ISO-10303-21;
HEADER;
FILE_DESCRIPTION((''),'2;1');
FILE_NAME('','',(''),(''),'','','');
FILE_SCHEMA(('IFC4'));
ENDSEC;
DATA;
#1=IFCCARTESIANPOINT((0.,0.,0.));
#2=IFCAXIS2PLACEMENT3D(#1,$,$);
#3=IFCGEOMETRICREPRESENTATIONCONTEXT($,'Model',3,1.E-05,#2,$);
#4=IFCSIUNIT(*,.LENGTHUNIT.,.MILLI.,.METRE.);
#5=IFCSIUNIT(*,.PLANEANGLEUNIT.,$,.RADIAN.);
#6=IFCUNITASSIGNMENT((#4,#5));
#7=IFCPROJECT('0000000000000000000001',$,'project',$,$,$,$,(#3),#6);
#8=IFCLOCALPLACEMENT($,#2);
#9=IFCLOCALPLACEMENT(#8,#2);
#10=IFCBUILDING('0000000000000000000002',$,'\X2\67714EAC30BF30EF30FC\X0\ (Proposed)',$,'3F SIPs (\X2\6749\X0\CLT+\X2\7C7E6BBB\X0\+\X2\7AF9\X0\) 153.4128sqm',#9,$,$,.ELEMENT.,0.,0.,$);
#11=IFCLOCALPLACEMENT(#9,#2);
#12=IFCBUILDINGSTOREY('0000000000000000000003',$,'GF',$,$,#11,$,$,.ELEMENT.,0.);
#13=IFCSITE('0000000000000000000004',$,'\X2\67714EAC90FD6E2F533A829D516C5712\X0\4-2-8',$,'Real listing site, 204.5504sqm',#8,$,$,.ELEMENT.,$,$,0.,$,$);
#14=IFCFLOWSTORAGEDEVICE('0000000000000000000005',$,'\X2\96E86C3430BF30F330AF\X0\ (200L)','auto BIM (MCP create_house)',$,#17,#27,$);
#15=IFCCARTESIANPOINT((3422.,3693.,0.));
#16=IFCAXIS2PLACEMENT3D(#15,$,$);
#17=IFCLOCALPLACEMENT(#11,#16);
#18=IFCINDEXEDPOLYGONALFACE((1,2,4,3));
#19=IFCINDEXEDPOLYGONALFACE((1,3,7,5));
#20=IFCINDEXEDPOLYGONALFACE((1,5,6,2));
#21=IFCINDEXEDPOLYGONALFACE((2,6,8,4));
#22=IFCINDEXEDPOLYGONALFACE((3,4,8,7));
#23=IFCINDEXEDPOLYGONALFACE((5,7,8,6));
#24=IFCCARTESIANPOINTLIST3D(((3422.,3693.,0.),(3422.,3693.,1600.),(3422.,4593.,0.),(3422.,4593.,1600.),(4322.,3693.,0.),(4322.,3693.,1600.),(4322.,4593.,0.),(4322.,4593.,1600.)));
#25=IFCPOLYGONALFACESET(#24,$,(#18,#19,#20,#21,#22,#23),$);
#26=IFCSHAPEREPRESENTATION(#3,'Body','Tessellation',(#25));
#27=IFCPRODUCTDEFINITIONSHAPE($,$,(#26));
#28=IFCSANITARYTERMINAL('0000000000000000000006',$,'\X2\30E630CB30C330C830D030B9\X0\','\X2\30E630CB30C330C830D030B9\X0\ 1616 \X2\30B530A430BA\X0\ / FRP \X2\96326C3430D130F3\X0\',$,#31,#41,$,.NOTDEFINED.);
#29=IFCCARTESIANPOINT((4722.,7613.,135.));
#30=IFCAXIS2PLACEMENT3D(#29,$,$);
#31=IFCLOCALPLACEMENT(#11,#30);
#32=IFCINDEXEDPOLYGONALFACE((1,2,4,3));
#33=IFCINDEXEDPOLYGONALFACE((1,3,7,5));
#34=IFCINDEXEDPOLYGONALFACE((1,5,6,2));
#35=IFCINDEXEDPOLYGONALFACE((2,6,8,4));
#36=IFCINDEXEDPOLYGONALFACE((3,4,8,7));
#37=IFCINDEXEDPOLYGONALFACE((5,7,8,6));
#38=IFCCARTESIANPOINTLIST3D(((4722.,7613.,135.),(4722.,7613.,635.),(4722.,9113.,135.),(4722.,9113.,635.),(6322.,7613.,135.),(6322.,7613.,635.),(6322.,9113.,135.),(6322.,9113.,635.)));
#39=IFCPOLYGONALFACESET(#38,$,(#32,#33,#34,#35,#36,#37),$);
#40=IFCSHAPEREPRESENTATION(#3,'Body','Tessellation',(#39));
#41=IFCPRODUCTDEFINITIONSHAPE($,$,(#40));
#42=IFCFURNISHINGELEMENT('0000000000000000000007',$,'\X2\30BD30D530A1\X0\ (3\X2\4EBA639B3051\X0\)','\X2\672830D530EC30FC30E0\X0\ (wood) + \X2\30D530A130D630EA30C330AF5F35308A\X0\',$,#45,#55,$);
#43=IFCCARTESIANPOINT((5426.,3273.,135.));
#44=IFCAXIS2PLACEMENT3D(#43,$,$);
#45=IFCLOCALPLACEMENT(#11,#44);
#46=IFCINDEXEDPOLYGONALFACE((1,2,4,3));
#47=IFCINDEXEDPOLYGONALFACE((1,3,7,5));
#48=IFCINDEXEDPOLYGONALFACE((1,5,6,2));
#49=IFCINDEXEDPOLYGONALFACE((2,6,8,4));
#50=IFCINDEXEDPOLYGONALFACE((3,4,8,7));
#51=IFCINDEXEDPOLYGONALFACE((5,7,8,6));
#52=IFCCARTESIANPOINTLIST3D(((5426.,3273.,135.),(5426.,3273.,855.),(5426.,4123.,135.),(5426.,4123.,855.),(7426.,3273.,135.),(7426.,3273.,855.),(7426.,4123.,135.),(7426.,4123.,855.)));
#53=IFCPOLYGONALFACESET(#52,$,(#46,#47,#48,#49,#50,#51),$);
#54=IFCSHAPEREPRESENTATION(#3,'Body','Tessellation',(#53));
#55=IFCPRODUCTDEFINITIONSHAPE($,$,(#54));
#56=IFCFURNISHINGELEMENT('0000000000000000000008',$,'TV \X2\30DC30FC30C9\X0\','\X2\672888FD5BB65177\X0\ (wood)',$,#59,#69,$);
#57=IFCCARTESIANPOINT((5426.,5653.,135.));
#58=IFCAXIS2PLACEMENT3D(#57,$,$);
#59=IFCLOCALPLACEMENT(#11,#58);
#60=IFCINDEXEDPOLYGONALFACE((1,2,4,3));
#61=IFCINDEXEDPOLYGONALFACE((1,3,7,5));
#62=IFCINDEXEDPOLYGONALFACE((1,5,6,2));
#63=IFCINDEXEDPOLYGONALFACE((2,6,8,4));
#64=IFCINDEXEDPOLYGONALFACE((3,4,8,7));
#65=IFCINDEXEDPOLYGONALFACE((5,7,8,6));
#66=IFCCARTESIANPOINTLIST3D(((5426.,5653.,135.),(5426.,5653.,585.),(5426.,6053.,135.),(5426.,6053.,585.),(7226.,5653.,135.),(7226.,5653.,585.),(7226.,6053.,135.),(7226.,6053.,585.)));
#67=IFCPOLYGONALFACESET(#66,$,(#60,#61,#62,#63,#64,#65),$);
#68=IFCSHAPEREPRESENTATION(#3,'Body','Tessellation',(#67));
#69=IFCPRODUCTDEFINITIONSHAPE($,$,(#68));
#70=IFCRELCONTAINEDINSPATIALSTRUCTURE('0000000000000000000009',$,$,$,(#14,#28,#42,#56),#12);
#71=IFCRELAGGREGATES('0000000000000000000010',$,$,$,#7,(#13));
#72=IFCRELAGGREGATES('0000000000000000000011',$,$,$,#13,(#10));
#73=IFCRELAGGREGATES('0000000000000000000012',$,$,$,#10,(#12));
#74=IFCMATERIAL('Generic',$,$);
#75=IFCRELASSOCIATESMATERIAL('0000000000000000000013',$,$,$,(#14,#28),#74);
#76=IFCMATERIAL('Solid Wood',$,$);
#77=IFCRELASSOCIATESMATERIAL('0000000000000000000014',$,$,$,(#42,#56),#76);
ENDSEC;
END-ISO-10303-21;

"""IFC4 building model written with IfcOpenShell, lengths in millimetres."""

from ifc_helpers import new_model, si_unit, frame, frame_2d, origin, place, context, project, spatial, rectangle, extrude, material, element, save


model = new_model("IFC4")

# Units and contexts
model_context = context("Model", 3, precision=1e-05, world=origin())
ifc_project = project(units=[si_unit("LENGTHUNIT", "METRE", prefix="MILLI"), si_unit("PLANEANGLEUNIT", "RADIAN")], contexts=[model_context])

# Site, building, storey
site_placement = place(None, origin())
site = spatial("IfcSite", under=ifc_project, at=site_placement, Name="東京都港区芝公園4-2-8", ObjectType="Real listing site, 204.5504sqm", CompositionType="ELEMENT", RefElevation=0.0)
building_placement = place(site_placement, origin())
building = spatial("IfcBuilding", under=site, at=building_placement, Name="東京タワー (Proposed)", ObjectType="3F SIPs (杉CLT+籾殻+竹) 153.4128sqm", CompositionType="ELEMENT", ElevationOfRefHeight=0.0, ElevationOfTerrain=0.0)
storey_placement = place(building_placement, origin())
storey = spatial("IfcBuildingStorey", under=building, at=storey_placement, Name="GF", CompositionType="ELEMENT", Elevation=0.0)

# Shared definitions
ifc_material_1 = material(Name="Solid Wood")

# Shared definitions
ifc_material_2 = material(Name="Generic")

# Flow storage device
flow_storage_device_placement = place(storey_placement, frame((3422.0, 3693.0, 0.0)))
element("IfcFlowStorageDevice", 1, at=flow_storage_device_placement, inside=storey, material=ifc_material_2, Name="雨水タンク (200L)", Description="auto BIM (MCP create_house)", context=model_context, shape_type="SweptSolid", body=[
    extrude(rectangle(XDim=900.0, YDim=900.0, at=frame_2d((450.0, 450.0))), frame((3422.0, 3693.0, 0.0)), (0.0, 0.0, 1.0), 1600.0),
])

# Sanitary terminal
sanitary_terminal_placement = place(storey_placement, frame((4722.0, 7613.0, 135.0)))
element("IfcSanitaryTerminal", 2, at=sanitary_terminal_placement, inside=storey, material=ifc_material_2, Name="ユニットバス", Description="ユニットバス 1616 サイズ / FRP 防水パン", PredefinedType="NOTDEFINED", context=model_context, shape_type="SweptSolid", body=[
    extrude(rectangle(XDim=1600.0, YDim=1500.0, at=frame_2d((800.0, 750.0))), frame((4722.0, 7613.0, 135.0)), (0.0, 0.0, 1.0), 500.0),
])

# Furnishing elements
furnishing_1_placement = place(storey_placement, frame((5426.0, 3273.0, 135.0)))
element("IfcFurnishingElement", 3, at=furnishing_1_placement, inside=storey, material=ifc_material_1, Name="ソファ (3人掛け)", Description="木フレーム (wood) + ファブリック張り", context=model_context, shape_type="SweptSolid", body=[
    extrude(rectangle(XDim=2000.0, YDim=850.0, at=frame_2d((1000.0, 425.0))), frame((5426.0, 3273.0, 135.0)), (0.0, 0.0, 1.0), 720.0),
])
furnishing_2_placement = place(storey_placement, frame((5426.0, 5653.0, 135.0)))
element("IfcFurnishingElement", 4, at=furnishing_2_placement, inside=storey, material=ifc_material_1, Name="TV ボード", Description="木製家具 (wood)", context=model_context, shape_type="SweptSolid", body=[
    extrude(rectangle(XDim=1800.0, YDim=400.0, at=frame_2d((900.0, 200.0))), frame((5426.0, 5653.0, 135.0)), (0.0, 0.0, 1.0), 450.0),
])

save(model, "model.ifc")
